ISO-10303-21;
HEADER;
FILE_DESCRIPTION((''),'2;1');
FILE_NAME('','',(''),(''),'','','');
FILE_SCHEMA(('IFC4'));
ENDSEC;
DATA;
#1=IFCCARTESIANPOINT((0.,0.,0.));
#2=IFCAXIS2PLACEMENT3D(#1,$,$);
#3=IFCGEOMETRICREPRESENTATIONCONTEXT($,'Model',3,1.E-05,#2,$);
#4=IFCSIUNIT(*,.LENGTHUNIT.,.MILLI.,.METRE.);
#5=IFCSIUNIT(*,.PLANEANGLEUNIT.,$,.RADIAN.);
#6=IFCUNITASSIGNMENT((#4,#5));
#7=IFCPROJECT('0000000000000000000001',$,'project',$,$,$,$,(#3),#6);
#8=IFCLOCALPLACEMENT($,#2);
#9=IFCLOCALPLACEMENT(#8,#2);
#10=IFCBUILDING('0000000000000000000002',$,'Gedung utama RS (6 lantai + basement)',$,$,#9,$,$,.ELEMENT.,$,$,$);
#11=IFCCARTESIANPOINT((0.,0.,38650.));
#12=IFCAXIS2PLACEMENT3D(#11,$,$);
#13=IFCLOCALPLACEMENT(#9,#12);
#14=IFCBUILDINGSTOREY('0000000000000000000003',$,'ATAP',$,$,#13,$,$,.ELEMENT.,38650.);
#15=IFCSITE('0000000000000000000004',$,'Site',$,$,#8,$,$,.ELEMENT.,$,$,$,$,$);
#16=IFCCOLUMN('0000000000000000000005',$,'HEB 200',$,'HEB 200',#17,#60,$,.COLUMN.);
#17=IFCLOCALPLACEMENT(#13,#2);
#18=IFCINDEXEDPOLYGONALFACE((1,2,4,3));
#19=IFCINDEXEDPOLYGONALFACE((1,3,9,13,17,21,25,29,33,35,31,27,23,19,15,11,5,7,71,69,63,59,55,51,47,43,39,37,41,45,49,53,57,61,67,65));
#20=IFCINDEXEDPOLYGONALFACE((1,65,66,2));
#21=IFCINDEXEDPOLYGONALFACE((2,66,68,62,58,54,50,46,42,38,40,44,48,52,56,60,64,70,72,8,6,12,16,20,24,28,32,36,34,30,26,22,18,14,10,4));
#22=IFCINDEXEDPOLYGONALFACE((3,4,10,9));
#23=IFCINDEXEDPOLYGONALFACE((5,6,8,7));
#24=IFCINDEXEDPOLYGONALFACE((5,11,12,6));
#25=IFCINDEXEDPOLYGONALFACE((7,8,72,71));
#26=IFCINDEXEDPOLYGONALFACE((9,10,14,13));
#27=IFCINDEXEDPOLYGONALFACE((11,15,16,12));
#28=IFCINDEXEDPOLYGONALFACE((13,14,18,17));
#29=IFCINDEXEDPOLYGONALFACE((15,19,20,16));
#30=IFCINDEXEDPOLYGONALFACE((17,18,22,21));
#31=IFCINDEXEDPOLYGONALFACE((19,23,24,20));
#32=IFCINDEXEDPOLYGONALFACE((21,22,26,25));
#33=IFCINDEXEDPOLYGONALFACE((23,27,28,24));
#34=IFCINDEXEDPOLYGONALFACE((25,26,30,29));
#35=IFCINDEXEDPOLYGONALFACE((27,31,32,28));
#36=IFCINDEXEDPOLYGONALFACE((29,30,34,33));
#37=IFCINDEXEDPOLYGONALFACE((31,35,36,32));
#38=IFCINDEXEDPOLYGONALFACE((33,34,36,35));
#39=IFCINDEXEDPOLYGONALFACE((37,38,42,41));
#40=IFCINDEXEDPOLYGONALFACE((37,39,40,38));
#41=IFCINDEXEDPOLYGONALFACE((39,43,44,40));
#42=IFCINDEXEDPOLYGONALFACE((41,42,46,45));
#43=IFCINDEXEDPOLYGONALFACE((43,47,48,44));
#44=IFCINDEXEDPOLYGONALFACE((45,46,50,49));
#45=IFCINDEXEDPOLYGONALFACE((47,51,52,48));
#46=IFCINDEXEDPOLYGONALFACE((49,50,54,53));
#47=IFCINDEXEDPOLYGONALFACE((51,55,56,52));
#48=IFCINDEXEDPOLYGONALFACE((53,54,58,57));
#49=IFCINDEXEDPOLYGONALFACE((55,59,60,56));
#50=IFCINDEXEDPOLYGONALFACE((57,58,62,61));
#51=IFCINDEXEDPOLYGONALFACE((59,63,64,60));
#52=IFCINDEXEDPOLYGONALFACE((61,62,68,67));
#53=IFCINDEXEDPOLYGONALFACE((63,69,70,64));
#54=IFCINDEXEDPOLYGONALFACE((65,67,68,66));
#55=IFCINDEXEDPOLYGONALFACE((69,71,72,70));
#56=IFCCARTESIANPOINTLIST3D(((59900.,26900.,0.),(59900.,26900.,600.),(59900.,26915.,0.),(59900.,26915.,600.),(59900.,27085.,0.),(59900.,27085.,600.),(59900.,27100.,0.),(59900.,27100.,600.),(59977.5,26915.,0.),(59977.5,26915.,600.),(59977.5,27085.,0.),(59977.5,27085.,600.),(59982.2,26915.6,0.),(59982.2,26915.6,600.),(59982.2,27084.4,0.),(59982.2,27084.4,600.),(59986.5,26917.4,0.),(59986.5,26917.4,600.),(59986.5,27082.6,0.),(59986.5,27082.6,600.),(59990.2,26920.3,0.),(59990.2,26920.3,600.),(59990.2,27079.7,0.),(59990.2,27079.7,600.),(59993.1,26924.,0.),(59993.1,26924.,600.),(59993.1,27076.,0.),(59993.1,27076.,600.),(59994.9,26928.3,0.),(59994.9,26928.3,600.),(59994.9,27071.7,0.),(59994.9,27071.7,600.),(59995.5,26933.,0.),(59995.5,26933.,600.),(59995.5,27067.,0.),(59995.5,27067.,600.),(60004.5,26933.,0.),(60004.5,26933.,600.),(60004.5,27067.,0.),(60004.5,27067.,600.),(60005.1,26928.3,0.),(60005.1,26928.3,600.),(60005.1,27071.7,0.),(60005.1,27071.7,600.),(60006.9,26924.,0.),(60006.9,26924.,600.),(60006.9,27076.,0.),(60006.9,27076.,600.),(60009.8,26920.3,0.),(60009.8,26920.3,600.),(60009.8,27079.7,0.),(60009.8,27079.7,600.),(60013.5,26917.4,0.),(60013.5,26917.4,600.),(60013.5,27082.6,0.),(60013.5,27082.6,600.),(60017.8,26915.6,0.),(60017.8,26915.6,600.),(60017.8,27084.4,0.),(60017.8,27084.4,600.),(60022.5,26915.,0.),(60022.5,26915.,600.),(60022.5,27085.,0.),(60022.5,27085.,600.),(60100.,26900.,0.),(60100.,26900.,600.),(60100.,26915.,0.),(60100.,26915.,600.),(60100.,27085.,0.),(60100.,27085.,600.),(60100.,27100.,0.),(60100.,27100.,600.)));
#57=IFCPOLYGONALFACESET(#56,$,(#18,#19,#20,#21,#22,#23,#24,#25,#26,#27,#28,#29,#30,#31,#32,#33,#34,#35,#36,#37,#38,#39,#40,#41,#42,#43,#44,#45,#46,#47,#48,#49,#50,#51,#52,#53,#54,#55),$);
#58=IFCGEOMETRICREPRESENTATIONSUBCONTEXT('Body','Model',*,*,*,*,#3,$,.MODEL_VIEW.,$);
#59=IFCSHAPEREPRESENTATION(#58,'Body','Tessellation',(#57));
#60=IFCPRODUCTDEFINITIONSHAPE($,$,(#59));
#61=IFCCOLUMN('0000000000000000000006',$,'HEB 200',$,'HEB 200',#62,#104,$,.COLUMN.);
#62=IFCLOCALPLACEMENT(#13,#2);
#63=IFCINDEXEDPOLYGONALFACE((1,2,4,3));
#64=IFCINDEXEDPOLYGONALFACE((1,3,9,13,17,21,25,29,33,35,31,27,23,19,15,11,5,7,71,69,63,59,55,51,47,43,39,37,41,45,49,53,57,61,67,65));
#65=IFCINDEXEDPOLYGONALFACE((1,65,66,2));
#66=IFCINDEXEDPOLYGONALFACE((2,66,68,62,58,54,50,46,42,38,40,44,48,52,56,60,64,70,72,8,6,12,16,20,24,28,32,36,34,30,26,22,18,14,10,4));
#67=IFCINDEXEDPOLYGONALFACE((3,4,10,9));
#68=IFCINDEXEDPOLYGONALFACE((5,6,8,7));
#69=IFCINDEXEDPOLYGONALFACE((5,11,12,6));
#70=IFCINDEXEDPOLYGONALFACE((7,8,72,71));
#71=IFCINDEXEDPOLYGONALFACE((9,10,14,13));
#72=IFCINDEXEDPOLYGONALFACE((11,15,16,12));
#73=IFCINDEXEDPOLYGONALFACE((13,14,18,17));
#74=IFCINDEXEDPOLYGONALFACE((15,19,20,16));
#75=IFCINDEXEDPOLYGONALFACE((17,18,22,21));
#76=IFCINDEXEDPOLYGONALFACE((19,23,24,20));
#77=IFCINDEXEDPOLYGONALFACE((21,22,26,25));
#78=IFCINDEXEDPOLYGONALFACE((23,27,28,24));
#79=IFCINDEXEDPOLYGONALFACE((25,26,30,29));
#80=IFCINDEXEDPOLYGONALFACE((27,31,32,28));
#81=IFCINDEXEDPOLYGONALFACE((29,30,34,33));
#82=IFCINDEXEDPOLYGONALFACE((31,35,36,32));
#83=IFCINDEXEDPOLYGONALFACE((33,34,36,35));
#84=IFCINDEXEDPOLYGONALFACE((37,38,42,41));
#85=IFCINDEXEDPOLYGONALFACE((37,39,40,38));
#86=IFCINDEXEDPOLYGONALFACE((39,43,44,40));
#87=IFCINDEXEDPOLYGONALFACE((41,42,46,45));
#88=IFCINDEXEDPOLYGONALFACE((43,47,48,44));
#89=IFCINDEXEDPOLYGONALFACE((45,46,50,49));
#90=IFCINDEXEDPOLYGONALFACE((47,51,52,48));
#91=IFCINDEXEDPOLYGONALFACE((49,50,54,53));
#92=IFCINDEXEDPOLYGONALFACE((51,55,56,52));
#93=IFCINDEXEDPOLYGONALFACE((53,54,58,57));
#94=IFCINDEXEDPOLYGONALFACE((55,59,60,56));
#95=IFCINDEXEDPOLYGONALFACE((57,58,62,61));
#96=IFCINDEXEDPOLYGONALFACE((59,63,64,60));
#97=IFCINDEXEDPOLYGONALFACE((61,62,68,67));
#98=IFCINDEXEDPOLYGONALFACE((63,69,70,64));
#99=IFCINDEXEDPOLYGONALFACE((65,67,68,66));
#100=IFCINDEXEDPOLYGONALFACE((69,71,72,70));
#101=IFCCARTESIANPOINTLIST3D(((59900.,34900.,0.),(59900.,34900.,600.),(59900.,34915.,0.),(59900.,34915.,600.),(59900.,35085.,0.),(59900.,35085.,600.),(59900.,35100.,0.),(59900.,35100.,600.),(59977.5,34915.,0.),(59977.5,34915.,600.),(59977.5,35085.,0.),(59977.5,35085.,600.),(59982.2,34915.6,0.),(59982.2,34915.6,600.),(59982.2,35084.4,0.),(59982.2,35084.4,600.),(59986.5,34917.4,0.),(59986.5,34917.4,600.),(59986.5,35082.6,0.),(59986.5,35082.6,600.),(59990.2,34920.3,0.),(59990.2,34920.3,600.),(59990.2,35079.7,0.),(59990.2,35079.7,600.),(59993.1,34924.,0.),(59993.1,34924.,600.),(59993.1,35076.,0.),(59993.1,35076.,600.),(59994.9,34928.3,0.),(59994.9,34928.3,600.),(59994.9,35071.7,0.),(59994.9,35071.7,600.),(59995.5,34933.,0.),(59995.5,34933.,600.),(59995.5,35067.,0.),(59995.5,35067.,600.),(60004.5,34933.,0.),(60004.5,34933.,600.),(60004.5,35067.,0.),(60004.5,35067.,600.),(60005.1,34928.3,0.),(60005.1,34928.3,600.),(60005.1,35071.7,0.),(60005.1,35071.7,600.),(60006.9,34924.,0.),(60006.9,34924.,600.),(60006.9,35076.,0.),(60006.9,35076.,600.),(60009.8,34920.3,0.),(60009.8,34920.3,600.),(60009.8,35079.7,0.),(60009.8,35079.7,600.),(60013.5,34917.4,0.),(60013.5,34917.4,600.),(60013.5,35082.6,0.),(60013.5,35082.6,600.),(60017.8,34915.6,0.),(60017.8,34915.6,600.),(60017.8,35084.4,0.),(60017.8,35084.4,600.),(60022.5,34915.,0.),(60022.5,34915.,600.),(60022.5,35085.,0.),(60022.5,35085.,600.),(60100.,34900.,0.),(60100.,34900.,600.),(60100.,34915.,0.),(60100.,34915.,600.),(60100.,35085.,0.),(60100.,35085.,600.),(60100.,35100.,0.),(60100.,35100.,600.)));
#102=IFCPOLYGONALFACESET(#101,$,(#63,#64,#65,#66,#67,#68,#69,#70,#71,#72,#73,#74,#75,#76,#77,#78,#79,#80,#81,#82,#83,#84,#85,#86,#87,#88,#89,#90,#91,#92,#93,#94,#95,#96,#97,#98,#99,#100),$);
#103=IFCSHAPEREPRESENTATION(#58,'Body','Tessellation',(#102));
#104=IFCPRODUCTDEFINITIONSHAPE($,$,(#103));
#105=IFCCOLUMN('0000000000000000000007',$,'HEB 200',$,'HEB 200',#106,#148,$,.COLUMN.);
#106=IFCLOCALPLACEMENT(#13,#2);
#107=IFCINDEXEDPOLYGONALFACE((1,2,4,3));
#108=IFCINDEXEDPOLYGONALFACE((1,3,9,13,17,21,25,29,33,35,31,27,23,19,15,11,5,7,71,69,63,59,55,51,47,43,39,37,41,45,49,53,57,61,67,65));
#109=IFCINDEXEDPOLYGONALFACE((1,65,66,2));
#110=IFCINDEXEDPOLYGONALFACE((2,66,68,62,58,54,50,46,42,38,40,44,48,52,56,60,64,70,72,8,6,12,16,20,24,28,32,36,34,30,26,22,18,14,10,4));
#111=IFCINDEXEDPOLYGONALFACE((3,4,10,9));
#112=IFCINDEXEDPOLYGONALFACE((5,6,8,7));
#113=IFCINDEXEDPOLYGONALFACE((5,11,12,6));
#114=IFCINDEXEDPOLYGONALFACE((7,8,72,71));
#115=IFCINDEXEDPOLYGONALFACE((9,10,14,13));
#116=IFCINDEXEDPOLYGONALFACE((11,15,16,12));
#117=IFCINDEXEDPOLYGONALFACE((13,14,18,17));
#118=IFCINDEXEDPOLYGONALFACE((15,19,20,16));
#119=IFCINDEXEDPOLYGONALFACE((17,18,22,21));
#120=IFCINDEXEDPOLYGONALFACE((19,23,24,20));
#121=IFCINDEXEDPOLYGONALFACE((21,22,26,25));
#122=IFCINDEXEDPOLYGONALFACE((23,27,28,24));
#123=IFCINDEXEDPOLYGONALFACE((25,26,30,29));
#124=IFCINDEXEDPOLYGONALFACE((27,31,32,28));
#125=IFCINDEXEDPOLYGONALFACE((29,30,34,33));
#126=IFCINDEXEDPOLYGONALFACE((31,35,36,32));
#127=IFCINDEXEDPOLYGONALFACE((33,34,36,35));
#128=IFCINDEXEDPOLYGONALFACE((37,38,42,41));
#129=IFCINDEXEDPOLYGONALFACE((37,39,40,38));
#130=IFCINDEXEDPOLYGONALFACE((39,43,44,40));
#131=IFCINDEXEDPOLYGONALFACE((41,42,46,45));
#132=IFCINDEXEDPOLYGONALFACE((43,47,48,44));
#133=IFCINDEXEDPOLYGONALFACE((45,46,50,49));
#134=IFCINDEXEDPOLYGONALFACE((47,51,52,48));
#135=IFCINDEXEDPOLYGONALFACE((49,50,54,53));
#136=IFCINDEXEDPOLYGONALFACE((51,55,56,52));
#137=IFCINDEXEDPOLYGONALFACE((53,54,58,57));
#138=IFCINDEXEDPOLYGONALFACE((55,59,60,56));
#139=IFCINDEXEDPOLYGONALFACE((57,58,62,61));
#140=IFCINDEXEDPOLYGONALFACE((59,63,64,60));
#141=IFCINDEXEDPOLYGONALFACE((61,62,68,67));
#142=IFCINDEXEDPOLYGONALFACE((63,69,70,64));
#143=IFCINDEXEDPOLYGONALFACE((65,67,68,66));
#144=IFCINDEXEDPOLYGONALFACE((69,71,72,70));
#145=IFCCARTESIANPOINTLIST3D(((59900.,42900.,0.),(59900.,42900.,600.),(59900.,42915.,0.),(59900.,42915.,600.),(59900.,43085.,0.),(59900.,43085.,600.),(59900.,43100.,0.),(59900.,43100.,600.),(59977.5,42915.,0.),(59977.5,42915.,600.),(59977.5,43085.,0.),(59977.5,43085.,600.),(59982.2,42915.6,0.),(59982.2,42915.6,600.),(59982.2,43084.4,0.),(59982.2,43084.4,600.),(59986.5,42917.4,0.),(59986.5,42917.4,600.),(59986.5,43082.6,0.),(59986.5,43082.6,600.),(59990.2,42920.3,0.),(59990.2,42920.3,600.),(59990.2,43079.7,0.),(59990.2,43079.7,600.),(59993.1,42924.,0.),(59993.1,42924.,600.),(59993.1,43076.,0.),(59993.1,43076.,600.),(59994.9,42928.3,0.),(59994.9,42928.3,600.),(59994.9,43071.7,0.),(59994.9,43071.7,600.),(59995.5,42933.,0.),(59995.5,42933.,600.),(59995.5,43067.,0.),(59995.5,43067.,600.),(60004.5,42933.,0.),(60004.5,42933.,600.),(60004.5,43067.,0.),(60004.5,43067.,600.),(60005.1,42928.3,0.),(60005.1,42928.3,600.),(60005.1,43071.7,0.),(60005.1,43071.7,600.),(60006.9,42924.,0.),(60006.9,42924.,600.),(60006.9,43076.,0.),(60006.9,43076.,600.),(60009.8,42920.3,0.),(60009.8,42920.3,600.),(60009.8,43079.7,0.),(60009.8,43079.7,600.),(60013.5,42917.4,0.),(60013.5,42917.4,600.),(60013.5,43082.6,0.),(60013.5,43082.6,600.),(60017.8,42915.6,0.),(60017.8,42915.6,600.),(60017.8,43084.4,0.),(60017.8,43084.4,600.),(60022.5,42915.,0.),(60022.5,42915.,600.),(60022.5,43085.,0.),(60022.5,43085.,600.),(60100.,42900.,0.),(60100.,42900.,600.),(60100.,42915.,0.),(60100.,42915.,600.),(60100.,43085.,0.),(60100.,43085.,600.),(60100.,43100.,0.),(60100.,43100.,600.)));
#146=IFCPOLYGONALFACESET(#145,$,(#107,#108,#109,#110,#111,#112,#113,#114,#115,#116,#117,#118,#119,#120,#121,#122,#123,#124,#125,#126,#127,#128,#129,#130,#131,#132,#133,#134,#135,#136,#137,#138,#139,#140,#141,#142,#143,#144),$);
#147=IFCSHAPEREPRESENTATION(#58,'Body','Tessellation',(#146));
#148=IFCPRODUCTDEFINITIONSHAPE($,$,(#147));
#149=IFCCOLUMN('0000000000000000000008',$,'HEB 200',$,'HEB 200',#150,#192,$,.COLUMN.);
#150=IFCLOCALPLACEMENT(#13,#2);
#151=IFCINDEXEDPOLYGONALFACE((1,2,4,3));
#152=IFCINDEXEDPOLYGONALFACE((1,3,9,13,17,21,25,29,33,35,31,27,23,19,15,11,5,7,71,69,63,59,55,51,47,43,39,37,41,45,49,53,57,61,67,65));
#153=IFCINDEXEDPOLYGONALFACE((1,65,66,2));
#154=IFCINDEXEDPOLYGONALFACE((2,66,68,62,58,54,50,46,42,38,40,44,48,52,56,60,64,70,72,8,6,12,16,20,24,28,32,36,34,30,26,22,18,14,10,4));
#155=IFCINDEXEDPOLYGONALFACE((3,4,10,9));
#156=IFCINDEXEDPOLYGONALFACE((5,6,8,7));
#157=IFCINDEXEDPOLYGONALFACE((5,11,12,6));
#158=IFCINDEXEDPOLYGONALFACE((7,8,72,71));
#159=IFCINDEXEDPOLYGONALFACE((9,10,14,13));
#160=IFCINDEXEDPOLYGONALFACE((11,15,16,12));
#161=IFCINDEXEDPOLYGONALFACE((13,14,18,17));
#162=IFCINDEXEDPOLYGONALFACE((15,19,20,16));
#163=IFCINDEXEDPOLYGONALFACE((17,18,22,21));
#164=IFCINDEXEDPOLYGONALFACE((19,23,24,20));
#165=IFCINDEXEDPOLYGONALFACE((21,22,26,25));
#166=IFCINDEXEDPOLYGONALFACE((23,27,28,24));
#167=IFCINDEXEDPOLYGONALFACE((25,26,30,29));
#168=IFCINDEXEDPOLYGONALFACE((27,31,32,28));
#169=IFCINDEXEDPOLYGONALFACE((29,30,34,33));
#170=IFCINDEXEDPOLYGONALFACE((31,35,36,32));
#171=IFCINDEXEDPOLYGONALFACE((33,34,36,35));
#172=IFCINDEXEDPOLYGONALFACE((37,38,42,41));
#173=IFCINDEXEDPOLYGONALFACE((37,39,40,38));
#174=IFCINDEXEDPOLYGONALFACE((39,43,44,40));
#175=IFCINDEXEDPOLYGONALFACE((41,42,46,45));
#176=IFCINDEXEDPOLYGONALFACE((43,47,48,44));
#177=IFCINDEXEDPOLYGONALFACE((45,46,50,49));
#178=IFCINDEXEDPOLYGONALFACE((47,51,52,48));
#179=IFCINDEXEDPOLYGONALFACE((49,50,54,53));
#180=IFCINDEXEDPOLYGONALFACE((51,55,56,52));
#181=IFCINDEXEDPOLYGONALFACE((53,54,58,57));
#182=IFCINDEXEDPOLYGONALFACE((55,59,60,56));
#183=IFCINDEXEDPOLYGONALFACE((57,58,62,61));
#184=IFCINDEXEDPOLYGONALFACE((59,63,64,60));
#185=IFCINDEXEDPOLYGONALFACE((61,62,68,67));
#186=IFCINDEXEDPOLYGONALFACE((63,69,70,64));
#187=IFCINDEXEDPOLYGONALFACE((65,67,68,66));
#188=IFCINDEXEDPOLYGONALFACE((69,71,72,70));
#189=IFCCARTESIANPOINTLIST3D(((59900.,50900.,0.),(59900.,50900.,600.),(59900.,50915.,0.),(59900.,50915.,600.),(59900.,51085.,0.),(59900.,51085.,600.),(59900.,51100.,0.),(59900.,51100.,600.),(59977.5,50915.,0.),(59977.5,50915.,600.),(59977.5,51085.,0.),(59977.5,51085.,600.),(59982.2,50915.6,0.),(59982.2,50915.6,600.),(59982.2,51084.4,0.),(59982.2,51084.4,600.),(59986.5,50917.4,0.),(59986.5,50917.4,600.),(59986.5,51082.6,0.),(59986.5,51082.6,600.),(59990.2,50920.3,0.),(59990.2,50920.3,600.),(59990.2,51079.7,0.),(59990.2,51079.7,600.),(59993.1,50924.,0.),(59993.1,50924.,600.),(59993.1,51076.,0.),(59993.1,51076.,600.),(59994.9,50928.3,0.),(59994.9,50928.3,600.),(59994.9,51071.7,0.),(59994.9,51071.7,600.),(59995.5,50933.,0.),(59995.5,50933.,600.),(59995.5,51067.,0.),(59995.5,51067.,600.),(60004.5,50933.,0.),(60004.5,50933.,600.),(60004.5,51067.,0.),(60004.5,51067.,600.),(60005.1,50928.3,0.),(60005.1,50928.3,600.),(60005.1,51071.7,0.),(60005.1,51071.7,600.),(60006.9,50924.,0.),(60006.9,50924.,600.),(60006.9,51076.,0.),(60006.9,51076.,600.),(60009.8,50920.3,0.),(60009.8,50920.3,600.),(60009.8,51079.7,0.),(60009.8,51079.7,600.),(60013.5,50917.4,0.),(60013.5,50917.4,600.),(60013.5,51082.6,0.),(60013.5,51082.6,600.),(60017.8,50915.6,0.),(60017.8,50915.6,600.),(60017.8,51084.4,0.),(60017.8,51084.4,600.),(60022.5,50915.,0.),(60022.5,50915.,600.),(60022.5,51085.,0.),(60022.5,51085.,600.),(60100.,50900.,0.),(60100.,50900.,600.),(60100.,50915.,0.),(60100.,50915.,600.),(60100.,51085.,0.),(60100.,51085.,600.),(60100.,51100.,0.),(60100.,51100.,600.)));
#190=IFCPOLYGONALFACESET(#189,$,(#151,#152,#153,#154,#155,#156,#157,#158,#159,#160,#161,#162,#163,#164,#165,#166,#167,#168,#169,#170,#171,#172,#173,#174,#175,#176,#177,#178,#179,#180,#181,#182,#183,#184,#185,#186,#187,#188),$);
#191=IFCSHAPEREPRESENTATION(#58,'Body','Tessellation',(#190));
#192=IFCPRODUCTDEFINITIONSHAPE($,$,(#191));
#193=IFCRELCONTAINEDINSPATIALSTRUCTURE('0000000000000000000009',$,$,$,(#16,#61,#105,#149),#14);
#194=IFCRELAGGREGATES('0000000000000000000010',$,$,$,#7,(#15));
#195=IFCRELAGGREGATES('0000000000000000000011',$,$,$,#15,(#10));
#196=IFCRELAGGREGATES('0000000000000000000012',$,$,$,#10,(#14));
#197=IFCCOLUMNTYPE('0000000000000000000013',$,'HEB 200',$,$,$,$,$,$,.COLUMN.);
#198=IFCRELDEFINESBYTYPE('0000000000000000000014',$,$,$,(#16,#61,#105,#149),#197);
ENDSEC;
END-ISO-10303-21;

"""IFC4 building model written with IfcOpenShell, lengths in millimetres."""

from ifc_helpers import new_model, si_unit, frame, origin, origin_2d, place, context, subcontext, project, spatial, i_section, extrude, material_profile, profile_set, profile_usage, type_object, element, save


model = new_model("IFC4")

# Units and contexts
model_context = context("Model", 3, precision=1e-05, world=origin())
body_context = subcontext(model_context, "Body", "Model", "MODEL_VIEW")
ifc_project = project(units=[si_unit("LENGTHUNIT", "METRE", prefix="MILLI"), si_unit("PLANEANGLEUNIT", "RADIAN")], contexts=[model_context])

# Site, building, storey
site_placement = place(None, origin())
site = spatial("IfcSite", under=ifc_project, at=site_placement, Name="Site", CompositionType="ELEMENT")
building_placement = place(site_placement, origin())
building = spatial("IfcBuilding", under=site, at=building_placement, Name="Gedung utama RS (6 lantai + basement)", CompositionType="ELEMENT")
storey_placement = place(building_placement, frame((0.0, 0.0, 38650.0)))
storey = spatial("IfcBuildingStorey", under=building, at=storey_placement, Name="ATAP", CompositionType="ELEMENT", Elevation=38650.0)

# Columns
ifc_material_profile_1 = material_profile(None, i_section(OverallWidth=200.0, OverallDepth=200.0, WebThickness=9.0, FlangeThickness=15.0, FilletRadius=18.0, at=origin_2d()), Name="HEB 200")
ifc_profile_set_1 = profile_set([ifc_material_profile_1], Name="HEB 200")
ifc_profile_usage_1 = profile_usage(ifc_profile_set_1, cardinal=5)
column_type = type_object("IfcColumnType", Name="HEB 200", PredefinedType="COLUMN", material=ifc_profile_set_1)
for number, where, z_axis, x_axis, name in (
    (1, (60000.0, 27000.0, 0.0), (0.0, 0.0, 1.0), (1.0, 0.0, 0.0), "HEB 200"),
    (2, (60000.0, 35000.0, 0.0), (0.0, 0.0, 1.0), (1.0, 0.0, 0.0), "HEB 200"),
    (3, (60000.0, 43000.0, 0.0), (0.0, 0.0, 1.0), (1.0, 0.0, 0.0), "HEB 200"),
    (4, (60000.0, 51000.0, 0.0), (0.0, 0.0, 1.0), (1.0, 0.0, 0.0), "HEB 200"),
):
    element("IfcColumn", number, at=place(storey_placement, frame(where, z_axis=z_axis, x_axis=x_axis)), inside=storey, type_object=column_type, material=ifc_profile_usage_1, Name=name, ObjectType="HEB 200", PredefinedType="COLUMN", context=body_context, shape_type="SweptSolid", body=[
        extrude(i_section(OverallWidth=200.0, OverallDepth=200.0, WebThickness=9.0, FlangeThickness=15.0, FilletRadius=18.0, at=origin_2d()), origin(), (0.0, 0.0, 1.0), 600.0),
    ])

save(model, "model.ifc")
